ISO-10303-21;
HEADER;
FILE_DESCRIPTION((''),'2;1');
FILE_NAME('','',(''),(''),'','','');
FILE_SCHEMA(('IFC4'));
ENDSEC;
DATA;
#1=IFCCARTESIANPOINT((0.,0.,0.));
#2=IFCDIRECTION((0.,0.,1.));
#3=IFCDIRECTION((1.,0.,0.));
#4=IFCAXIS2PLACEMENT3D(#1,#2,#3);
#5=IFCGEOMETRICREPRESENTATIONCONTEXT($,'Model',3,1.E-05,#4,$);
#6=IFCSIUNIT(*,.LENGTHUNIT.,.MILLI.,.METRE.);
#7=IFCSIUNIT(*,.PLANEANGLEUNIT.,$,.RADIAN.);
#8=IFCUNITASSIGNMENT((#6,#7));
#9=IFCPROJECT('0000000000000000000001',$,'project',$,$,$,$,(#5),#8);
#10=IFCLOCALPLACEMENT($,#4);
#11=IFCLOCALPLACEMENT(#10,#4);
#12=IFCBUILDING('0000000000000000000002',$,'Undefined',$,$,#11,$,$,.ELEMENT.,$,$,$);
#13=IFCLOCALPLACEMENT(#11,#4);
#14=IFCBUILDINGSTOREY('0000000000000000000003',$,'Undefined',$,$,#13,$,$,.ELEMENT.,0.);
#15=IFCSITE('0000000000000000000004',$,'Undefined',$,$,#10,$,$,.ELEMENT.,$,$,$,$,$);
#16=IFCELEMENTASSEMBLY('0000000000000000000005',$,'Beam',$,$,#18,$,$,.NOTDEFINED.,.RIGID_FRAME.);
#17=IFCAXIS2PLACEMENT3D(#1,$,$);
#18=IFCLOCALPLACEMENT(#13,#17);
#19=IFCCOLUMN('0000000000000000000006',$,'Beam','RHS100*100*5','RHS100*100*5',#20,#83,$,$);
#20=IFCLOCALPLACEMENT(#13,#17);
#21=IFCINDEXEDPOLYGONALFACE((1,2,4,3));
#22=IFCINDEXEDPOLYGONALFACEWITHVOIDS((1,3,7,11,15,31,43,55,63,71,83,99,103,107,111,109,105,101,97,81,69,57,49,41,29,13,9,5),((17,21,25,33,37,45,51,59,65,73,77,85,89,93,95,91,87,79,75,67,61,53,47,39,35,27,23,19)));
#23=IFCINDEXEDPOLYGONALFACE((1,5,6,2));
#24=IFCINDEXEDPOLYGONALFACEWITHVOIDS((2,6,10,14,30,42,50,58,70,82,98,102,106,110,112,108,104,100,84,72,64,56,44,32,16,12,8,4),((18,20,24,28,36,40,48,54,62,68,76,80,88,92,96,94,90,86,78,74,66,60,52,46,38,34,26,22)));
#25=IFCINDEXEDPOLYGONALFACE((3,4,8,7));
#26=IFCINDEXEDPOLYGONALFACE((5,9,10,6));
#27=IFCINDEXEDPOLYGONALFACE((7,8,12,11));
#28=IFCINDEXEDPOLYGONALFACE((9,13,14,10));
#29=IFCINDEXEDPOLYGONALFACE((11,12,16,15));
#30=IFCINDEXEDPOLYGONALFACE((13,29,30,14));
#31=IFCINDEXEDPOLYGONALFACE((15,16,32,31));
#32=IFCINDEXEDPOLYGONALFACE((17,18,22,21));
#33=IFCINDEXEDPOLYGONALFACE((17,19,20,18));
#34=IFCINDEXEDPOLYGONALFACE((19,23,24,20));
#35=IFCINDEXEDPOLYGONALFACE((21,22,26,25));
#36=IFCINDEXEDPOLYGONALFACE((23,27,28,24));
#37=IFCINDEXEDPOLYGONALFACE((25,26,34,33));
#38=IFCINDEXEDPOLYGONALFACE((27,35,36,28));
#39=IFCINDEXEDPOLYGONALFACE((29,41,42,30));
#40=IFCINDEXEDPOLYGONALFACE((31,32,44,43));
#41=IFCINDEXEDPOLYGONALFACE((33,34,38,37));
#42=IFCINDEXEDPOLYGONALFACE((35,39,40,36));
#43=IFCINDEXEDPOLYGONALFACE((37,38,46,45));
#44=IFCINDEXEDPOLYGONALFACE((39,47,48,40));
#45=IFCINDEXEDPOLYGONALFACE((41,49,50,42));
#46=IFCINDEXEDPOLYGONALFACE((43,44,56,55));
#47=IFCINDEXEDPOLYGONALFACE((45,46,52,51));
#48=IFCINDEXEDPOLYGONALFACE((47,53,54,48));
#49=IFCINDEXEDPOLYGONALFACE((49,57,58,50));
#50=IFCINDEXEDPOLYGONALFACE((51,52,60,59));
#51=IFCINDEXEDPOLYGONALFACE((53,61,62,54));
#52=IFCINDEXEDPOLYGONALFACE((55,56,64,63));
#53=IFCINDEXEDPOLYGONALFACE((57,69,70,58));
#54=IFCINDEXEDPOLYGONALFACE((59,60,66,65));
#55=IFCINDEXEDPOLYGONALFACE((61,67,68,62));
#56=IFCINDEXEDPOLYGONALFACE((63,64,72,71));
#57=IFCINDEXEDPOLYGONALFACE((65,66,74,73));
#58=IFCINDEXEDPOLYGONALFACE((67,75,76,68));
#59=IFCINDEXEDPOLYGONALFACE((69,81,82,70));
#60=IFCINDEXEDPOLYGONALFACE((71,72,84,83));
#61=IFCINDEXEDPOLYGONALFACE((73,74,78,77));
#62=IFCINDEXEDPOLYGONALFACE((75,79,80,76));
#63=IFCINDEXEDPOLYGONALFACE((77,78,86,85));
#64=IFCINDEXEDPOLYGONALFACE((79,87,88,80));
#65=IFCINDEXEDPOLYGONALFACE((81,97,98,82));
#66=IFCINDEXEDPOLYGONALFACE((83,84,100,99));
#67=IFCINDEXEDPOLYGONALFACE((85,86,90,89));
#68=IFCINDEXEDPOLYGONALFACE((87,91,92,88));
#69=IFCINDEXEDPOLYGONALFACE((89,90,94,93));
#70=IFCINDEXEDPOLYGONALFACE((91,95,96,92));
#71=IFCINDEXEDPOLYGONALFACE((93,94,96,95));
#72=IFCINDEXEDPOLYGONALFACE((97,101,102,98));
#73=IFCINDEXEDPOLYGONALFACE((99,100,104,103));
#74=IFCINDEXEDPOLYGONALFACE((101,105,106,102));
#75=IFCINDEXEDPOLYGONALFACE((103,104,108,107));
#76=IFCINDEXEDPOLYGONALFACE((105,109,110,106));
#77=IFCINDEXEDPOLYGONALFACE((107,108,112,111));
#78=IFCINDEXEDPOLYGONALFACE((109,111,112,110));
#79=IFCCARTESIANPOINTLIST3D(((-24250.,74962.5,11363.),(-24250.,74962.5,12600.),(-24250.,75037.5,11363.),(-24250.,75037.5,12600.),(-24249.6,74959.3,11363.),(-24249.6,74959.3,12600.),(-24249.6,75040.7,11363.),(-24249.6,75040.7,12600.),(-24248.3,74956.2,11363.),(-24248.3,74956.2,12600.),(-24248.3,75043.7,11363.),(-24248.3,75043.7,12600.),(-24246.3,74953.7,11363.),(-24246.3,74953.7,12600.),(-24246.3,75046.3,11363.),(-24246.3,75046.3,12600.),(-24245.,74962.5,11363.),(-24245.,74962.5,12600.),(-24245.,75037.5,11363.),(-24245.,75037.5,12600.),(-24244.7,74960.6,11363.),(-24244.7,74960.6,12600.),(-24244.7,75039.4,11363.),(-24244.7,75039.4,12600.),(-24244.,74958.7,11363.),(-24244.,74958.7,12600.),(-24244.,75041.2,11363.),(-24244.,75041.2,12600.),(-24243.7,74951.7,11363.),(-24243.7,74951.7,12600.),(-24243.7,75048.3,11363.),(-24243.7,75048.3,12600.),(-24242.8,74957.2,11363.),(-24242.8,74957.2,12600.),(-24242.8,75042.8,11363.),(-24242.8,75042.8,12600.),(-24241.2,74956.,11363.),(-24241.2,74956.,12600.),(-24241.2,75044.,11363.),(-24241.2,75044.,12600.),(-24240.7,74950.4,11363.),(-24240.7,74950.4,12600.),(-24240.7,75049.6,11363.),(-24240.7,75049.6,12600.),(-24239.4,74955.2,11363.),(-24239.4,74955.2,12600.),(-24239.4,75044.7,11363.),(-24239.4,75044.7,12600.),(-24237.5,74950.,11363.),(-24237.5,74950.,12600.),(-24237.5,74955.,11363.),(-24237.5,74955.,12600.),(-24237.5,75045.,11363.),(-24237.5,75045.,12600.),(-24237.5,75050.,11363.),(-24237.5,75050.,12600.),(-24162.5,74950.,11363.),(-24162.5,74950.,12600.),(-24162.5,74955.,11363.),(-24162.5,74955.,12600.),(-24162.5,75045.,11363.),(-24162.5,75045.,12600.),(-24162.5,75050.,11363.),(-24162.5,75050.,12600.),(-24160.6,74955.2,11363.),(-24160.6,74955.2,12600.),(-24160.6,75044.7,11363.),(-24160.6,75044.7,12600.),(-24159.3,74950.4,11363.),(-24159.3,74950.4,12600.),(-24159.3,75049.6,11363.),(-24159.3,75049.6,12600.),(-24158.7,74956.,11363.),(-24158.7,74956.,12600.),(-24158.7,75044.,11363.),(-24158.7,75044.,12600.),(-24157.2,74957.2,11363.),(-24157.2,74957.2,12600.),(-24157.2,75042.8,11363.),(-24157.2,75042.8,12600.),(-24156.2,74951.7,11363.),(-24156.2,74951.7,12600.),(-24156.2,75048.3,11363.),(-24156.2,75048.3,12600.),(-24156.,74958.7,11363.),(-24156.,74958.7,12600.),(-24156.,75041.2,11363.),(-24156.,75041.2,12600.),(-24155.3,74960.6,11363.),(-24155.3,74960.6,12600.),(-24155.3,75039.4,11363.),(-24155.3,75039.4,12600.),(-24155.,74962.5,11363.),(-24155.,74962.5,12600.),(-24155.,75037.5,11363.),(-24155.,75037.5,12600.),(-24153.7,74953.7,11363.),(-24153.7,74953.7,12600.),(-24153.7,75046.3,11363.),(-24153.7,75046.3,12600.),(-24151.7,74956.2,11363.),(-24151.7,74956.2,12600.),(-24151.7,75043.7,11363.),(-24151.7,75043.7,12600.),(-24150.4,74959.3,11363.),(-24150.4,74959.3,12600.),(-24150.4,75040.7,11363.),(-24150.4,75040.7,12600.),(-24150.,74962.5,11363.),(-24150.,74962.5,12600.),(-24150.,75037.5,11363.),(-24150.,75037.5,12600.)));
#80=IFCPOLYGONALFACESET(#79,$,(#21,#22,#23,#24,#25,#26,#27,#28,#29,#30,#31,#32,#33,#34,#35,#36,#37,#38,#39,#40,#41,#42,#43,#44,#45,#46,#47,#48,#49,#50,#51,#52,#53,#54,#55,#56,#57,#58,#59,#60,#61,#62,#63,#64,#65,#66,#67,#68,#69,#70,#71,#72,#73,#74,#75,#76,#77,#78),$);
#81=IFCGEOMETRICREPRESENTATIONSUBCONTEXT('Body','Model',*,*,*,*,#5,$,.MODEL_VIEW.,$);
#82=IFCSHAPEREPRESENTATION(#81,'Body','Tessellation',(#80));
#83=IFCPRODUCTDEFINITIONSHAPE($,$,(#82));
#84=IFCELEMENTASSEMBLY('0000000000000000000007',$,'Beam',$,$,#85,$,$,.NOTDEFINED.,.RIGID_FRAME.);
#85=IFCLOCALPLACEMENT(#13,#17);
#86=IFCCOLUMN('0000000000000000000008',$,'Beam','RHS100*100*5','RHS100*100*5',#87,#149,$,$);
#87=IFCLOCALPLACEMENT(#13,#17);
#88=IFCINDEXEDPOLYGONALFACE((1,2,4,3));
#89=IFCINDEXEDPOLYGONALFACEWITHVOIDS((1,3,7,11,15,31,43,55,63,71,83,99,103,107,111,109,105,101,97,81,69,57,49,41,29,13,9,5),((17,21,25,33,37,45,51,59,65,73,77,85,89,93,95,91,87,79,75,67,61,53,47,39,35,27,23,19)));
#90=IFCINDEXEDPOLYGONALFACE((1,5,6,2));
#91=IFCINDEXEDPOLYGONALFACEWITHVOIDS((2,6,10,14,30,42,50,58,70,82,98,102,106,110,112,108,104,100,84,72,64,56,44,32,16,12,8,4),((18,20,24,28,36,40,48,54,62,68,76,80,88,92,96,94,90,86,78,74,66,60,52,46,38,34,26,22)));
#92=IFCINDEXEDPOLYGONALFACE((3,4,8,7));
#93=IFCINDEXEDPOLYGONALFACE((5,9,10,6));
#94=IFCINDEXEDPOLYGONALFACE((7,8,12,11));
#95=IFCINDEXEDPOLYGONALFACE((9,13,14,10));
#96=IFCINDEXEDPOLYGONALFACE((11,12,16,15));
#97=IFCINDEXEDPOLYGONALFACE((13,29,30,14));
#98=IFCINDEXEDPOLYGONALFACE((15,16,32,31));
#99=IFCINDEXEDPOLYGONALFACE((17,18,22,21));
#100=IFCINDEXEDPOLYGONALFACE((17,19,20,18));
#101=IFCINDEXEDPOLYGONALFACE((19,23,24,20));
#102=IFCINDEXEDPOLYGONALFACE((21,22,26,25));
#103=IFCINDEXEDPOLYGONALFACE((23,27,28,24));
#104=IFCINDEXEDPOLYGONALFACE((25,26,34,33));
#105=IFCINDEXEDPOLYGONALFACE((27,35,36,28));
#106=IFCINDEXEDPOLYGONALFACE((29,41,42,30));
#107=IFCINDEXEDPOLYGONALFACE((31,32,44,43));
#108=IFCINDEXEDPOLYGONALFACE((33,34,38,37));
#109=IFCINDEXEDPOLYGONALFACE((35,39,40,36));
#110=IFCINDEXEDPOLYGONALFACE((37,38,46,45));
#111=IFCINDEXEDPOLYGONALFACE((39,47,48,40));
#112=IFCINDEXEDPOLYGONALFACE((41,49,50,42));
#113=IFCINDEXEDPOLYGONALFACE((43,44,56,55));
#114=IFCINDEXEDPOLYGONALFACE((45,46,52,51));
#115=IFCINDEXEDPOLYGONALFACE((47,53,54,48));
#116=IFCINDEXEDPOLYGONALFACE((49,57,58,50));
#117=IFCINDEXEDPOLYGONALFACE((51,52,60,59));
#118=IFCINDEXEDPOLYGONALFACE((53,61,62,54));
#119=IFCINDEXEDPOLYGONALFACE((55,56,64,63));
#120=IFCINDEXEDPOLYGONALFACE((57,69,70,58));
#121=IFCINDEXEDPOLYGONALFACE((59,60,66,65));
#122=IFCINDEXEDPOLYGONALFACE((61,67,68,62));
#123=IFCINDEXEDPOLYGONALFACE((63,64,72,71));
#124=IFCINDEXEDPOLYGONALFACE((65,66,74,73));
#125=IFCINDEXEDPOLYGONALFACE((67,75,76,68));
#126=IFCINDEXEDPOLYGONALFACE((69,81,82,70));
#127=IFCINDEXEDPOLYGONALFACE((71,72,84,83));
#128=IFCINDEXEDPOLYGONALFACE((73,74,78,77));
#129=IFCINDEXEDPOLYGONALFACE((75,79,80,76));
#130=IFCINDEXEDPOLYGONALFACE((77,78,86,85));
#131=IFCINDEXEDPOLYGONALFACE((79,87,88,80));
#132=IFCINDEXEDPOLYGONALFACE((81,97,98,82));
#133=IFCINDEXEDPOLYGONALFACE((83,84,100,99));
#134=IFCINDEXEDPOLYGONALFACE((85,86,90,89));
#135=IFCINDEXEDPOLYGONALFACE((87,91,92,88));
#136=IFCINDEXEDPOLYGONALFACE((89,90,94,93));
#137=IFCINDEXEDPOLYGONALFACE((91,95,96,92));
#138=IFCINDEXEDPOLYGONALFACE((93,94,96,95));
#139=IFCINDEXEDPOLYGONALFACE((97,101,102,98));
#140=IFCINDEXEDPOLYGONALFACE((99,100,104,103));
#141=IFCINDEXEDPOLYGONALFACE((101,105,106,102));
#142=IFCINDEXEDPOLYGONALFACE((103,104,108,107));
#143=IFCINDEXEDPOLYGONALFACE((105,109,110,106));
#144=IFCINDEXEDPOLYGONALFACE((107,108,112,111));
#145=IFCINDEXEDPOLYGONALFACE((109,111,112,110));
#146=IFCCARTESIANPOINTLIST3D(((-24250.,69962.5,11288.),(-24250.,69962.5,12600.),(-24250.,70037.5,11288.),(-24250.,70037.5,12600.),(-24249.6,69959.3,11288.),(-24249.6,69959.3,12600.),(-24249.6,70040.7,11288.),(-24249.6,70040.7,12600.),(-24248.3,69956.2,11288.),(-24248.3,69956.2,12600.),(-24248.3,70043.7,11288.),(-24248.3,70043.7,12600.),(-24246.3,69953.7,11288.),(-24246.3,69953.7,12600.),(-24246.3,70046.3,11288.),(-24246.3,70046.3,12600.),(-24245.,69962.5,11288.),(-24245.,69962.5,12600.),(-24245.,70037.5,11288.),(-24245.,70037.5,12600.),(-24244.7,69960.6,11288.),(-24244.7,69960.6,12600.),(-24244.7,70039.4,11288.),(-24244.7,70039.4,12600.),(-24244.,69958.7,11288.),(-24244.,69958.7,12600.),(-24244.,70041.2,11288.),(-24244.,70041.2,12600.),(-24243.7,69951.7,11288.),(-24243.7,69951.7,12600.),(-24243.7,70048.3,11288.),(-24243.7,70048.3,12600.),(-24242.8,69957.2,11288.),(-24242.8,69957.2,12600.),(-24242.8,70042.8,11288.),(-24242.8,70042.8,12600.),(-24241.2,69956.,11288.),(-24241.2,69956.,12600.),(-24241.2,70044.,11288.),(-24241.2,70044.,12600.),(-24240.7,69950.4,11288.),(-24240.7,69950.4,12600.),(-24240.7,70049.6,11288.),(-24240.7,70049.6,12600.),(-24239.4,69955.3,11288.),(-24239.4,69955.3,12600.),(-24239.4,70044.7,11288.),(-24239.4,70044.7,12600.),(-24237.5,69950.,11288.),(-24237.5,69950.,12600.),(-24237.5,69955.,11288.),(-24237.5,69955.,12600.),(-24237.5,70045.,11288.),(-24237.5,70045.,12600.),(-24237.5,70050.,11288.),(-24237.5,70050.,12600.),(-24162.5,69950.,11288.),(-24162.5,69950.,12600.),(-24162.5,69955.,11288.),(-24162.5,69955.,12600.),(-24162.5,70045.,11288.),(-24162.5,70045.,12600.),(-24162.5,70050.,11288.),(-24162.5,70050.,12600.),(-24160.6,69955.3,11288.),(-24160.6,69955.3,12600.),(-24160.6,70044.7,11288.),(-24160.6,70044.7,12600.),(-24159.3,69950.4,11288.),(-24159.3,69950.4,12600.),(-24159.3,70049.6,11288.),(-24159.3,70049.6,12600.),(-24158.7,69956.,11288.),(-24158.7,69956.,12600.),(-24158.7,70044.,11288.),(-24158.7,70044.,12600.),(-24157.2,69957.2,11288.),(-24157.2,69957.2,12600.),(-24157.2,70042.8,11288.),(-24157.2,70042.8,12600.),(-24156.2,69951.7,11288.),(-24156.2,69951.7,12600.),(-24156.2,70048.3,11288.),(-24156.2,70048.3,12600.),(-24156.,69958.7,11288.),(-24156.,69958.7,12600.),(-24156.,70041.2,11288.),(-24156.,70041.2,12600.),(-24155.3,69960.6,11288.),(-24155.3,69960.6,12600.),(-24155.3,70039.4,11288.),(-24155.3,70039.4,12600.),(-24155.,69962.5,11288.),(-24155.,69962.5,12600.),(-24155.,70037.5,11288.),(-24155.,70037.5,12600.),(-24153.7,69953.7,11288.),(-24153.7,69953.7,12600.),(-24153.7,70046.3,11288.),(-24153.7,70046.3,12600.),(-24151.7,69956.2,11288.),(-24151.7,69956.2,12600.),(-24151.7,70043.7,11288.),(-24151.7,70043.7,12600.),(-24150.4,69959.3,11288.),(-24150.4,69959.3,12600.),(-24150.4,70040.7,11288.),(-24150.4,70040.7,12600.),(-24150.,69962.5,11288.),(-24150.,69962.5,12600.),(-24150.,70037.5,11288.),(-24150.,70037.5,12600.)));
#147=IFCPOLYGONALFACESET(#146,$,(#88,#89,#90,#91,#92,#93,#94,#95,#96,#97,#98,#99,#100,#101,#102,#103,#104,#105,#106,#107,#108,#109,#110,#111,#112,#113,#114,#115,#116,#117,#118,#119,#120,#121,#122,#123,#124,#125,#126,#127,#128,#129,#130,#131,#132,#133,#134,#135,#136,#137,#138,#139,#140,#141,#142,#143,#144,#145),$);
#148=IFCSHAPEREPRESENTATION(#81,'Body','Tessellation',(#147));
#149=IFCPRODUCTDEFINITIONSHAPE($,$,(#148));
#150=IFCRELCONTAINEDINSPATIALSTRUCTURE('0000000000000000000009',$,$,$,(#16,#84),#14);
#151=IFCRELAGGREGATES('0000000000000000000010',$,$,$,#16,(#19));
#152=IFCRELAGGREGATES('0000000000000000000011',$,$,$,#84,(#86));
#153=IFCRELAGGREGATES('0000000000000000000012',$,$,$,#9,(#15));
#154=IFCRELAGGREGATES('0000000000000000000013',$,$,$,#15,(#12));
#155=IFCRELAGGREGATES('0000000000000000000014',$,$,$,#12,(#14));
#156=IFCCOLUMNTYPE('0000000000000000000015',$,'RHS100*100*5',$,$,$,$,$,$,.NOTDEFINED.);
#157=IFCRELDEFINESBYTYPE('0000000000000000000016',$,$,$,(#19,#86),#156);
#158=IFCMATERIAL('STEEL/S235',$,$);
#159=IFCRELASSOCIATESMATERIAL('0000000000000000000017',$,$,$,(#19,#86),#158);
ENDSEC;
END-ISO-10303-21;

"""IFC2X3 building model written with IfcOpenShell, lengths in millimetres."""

from ifc_helpers import new_model, si_unit, frame, origin_with_axes, origin_2d_with_axis, place, context, subcontext, project, spatial, hollow_rectangle, extrude, material, type_object, element, aggregate, save


model = new_model("IFC2X3")

# Units and contexts
model_context = context("Model", 3, precision=1e-05, world=origin_with_axes())
body_context = subcontext(model_context, "Body", "Model", "MODEL_VIEW")
ifc_project = project(units=[si_unit("LENGTHUNIT", "METRE", prefix="MILLI"), si_unit("PLANEANGLEUNIT", "RADIAN")], contexts=[model_context])

# Site, building, storey
site_placement = place(None, origin_with_axes())
site = spatial("IfcSite", under=ifc_project, at=site_placement, Name="Undefined", CompositionType="ELEMENT")
building_placement = place(site_placement, origin_with_axes())
building = spatial("IfcBuilding", under=site, at=building_placement, Name="Undefined", CompositionType="ELEMENT")
storey_placement = place(building_placement, origin_with_axes())
storey = spatial("IfcBuildingStorey", under=building, at=storey_placement, Name="Undefined", CompositionType="ELEMENT", Elevation=0.0)

# Element assemblies, columns
assembly_1_placement = place(storey_placement, origin_with_axes())
assembly_1 = element("IfcElementAssembly", 1, at=assembly_1_placement, inside=storey, Name="Beam", AssemblyPlace="NOTDEFINED", PredefinedType="RIGID_FRAME")
ifc_material_1 = material(Name="STEEL/S235")
column_type = type_object("IfcColumnType", Name="RHS100*100*5", PredefinedType="NOTDEFINED")
column_1_placement = place(assembly_1_placement, frame((-24200.0, 75000.0, 11363.0), z_axis=(0.0, 0.0, 1.0), x_axis=(1.0, 0.0, 0.0)))
column_1 = element("IfcColumn", 2, at=column_1_placement, type_object=column_type, material=ifc_material_1, Name="Beam", Description="RHS100*100*5", ObjectType="RHS100*100*5", context=body_context, shape_type="SweptSolid", body=[
    extrude(hollow_rectangle(XDim=100.0, YDim=100.0, WallThickness=5.0, InnerFilletRadius=7.5, OuterFilletRadius=12.5, at=origin_2d_with_axis()), frame((0.0, 0.0, 1237.0), z_axis=(0.0, 0.0, -1.0), x_axis=(0.0, 1.0, 0.0)), (0.0, 0.0, 1.0), 1237.0),
])
aggregate(assembly_1, [column_1])
assembly_2_placement = place(storey_placement, origin_with_axes())
assembly_2 = element("IfcElementAssembly", 3, at=assembly_2_placement, inside=storey, Name="Beam", AssemblyPlace="NOTDEFINED", PredefinedType="RIGID_FRAME")
column_2_placement = place(assembly_2_placement, frame((-24200.0, 70000.0, 11288.0), z_axis=(0.0, 0.000002, 1.0), x_axis=(1.0, 0.0, 0.0)))
column_2 = element("IfcColumn", 4, at=column_2_placement, type_object=column_type, material=ifc_material_1, Name="Beam", Description="RHS100*100*5", ObjectType="RHS100*100*5", context=body_context, shape_type="SweptSolid", body=[
    extrude(hollow_rectangle(XDim=100.0, YDim=100.0, WallThickness=5.0, InnerFilletRadius=7.5, OuterFilletRadius=12.5, at=origin_2d_with_axis()), frame((0.0, 0.0, 1312.0), z_axis=(0.0, 0.0, -1.0), x_axis=(0.0, 1.0, 0.0)), (0.0, 0.0, 1.0), 1312.0),
])
aggregate(assembly_2, [column_2])

save(model, "model.ifc")
